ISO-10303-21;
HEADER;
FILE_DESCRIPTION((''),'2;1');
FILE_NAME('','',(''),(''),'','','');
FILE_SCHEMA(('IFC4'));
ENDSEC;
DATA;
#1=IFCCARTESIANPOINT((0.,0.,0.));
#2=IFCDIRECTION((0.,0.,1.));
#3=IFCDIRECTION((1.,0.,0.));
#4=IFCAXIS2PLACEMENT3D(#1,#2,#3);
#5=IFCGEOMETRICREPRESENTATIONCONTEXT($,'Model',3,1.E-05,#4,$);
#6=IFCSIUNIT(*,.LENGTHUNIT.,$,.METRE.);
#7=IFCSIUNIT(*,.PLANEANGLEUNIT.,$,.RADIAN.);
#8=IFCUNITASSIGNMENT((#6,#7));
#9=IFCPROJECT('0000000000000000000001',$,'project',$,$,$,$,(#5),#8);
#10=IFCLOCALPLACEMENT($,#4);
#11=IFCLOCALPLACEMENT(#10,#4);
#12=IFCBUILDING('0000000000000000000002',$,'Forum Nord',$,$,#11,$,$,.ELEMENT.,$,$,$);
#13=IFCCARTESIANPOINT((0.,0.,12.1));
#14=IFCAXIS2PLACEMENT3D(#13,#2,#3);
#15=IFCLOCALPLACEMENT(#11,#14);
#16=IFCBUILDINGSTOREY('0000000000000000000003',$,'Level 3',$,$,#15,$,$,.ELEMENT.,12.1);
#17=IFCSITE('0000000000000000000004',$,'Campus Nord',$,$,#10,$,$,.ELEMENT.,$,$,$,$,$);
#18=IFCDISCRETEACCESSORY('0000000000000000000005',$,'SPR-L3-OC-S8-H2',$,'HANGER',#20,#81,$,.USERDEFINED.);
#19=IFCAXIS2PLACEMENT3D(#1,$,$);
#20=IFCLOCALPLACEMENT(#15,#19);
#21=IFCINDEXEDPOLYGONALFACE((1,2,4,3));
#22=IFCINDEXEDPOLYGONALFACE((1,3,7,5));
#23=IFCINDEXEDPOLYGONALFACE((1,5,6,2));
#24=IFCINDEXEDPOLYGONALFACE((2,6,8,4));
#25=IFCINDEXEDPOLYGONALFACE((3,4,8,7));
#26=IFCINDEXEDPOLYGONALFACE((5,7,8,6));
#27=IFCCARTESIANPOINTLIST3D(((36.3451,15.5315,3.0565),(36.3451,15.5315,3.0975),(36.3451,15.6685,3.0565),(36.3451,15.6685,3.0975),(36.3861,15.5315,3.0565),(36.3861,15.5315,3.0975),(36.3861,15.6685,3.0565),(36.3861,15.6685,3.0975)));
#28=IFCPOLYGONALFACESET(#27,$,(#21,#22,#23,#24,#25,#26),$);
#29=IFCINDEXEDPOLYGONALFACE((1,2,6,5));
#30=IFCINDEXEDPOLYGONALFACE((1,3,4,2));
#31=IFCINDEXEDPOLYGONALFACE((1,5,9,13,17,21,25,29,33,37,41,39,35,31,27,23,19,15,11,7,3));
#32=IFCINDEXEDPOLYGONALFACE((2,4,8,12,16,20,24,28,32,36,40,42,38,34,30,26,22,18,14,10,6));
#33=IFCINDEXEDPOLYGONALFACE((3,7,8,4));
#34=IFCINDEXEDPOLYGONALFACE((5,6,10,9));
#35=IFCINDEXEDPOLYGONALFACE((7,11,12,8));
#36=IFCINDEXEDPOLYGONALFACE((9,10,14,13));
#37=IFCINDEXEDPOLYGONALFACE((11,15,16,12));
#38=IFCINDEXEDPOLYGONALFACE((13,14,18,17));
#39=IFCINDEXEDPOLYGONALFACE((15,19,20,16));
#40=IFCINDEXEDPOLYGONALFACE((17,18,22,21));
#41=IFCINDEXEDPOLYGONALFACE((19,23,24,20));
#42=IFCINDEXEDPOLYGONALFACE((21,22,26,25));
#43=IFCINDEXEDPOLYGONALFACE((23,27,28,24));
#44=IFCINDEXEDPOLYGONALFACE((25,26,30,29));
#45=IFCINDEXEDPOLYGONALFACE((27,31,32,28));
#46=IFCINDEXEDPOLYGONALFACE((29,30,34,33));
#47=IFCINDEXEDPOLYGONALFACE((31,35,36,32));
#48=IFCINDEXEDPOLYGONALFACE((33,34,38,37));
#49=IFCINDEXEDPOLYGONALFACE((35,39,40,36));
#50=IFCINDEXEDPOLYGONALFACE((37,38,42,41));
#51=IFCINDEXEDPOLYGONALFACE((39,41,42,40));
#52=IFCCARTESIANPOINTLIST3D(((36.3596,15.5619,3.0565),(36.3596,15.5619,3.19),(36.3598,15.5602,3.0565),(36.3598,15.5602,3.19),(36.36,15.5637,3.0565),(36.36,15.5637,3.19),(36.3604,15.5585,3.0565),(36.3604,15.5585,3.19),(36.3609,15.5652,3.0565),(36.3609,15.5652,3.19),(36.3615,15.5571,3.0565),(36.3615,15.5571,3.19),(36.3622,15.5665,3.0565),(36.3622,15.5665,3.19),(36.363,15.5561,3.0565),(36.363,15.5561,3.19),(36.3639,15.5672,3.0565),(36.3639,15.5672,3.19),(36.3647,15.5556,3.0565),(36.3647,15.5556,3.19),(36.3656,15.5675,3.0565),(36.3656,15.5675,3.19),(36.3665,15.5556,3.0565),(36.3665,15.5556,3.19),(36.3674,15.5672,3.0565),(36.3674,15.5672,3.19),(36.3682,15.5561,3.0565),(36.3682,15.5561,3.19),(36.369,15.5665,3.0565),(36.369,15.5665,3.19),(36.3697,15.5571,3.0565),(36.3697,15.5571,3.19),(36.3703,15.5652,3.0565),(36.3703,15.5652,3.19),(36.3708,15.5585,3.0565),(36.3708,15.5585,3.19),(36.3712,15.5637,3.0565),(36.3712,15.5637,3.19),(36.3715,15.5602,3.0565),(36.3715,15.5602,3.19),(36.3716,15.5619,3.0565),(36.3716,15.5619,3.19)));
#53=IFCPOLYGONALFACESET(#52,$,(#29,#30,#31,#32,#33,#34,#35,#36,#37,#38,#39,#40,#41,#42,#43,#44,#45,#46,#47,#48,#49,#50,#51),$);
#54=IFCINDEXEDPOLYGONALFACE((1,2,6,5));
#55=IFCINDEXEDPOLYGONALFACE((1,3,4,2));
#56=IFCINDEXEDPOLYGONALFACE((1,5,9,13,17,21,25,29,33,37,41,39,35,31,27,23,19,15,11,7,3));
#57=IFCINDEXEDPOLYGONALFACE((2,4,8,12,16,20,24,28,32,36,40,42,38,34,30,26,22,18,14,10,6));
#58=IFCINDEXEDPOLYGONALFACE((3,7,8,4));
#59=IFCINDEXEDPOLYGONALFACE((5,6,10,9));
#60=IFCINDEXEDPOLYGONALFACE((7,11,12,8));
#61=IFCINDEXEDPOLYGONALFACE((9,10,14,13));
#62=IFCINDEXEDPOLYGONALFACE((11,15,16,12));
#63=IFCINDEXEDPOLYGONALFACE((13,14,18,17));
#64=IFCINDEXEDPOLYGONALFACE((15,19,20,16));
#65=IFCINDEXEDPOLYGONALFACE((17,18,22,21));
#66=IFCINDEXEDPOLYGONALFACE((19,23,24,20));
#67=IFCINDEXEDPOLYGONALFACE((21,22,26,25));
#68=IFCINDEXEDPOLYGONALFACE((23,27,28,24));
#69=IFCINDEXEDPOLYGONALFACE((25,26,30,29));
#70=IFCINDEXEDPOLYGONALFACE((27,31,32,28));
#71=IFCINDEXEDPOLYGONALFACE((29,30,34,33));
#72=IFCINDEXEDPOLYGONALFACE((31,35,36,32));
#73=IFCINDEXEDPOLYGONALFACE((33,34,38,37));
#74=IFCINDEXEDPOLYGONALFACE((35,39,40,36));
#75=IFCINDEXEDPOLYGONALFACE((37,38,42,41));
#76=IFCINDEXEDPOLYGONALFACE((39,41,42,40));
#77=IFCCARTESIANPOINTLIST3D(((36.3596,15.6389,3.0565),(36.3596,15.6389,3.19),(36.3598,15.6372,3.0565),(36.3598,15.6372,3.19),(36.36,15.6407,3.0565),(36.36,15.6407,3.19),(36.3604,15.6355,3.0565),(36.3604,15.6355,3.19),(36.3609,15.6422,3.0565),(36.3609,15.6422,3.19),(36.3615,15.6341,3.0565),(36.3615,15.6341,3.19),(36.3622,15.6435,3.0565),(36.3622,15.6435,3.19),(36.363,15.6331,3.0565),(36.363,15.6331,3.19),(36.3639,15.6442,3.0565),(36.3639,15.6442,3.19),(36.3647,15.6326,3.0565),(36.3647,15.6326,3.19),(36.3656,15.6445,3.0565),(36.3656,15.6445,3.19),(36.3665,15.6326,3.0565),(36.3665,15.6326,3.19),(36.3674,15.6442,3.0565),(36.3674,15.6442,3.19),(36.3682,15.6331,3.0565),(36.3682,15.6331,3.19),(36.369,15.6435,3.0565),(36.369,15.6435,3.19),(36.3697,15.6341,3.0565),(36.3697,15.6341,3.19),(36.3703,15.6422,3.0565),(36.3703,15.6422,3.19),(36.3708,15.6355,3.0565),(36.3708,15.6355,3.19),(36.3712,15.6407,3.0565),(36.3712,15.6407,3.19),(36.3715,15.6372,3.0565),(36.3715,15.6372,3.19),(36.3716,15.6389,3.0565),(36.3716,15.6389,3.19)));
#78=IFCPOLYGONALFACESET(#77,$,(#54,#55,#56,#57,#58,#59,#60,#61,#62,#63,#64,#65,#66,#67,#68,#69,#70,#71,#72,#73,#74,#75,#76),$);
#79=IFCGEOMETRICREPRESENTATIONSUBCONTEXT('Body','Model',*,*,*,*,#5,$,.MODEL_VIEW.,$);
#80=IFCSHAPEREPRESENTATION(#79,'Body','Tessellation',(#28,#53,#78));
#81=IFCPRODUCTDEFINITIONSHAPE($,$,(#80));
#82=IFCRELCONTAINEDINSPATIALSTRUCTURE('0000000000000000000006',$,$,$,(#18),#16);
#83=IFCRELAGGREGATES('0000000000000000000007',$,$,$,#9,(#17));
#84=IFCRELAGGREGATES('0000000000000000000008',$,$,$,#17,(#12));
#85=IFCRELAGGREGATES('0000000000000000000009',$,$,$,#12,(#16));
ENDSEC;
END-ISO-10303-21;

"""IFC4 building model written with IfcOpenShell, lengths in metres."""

from ifc_helpers import new_model, si_unit, frame, frame_2d, origin_with_axes, origin_2d_with_axis, place, context, subcontext, project, spatial, rectangle, circle, extrude, element, save


model = new_model("IFC4")

# Units and contexts
model_context = context("Model", 3, precision=1e-05, world=origin_with_axes())
body_context = subcontext(model_context, "Body", "Model", "MODEL_VIEW")
ifc_project = project(units=[si_unit("LENGTHUNIT", "METRE"), si_unit("PLANEANGLEUNIT", "RADIAN")], contexts=[model_context])

# Site, building, storey
site_placement = place(None, origin_with_axes())
site = spatial("IfcSite", under=ifc_project, at=site_placement, Name="Campus Nord", CompositionType="ELEMENT")
building_placement = place(site_placement, origin_with_axes())
building = spatial("IfcBuilding", under=site, at=building_placement, Name="Forum Nord", CompositionType="ELEMENT")
storey_placement = place(building_placement, frame((0.0, 0.0, 12.1), z_axis=(0.0, 0.0, 1.0), x_axis=(1.0, 0.0, 0.0)))
storey = spatial("IfcBuildingStorey", under=building, at=storey_placement, Name="Level 3", CompositionType="ELEMENT", Elevation=12.1)

# Discrete accessory
for number, where, z_axis, x_axis, name in (
    (1, (36.3656, 15.6, 3.0975), (0.0, 0.0, 1.0), (0.0, 1.0, 0.0), "SPR-L3-OC-S8-H2"),
):
    element("IfcDiscreteAccessory", number, at=place(storey_placement, frame(where, z_axis=z_axis, x_axis=x_axis)), inside=storey, Name=name, ObjectType="HANGER", PredefinedType="USERDEFINED", context=body_context, shape_type="SweptSolid", body=[
        extrude(rectangle(XDim=0.137, YDim=0.041, at=origin_2d_with_axis()), frame((0.0, 0.0, -0.041), z_axis=(0.0, 0.0, 1.0), x_axis=(1.0, 0.0, 0.0)), (0.0, 0.0, 1.0), 0.041),
        extrude(circle(Radius=0.006, at=frame_2d((-0.0385, 0.0), x_axis=(1.0, 0.0))), frame((0.0, 0.0, -0.041), z_axis=(0.0, 0.0, 1.0), x_axis=(1.0, 0.0, 0.0)), (0.0, 0.0, 1.0), 0.1335),
        extrude(circle(Radius=0.006, at=frame_2d((0.0385, 0.0), x_axis=(1.0, 0.0))), frame((0.0, 0.0, -0.041), z_axis=(0.0, 0.0, 1.0), x_axis=(1.0, 0.0, 0.0)), (0.0, 0.0, 1.0), 0.1335),
    ])

save(model, "model.ifc")
